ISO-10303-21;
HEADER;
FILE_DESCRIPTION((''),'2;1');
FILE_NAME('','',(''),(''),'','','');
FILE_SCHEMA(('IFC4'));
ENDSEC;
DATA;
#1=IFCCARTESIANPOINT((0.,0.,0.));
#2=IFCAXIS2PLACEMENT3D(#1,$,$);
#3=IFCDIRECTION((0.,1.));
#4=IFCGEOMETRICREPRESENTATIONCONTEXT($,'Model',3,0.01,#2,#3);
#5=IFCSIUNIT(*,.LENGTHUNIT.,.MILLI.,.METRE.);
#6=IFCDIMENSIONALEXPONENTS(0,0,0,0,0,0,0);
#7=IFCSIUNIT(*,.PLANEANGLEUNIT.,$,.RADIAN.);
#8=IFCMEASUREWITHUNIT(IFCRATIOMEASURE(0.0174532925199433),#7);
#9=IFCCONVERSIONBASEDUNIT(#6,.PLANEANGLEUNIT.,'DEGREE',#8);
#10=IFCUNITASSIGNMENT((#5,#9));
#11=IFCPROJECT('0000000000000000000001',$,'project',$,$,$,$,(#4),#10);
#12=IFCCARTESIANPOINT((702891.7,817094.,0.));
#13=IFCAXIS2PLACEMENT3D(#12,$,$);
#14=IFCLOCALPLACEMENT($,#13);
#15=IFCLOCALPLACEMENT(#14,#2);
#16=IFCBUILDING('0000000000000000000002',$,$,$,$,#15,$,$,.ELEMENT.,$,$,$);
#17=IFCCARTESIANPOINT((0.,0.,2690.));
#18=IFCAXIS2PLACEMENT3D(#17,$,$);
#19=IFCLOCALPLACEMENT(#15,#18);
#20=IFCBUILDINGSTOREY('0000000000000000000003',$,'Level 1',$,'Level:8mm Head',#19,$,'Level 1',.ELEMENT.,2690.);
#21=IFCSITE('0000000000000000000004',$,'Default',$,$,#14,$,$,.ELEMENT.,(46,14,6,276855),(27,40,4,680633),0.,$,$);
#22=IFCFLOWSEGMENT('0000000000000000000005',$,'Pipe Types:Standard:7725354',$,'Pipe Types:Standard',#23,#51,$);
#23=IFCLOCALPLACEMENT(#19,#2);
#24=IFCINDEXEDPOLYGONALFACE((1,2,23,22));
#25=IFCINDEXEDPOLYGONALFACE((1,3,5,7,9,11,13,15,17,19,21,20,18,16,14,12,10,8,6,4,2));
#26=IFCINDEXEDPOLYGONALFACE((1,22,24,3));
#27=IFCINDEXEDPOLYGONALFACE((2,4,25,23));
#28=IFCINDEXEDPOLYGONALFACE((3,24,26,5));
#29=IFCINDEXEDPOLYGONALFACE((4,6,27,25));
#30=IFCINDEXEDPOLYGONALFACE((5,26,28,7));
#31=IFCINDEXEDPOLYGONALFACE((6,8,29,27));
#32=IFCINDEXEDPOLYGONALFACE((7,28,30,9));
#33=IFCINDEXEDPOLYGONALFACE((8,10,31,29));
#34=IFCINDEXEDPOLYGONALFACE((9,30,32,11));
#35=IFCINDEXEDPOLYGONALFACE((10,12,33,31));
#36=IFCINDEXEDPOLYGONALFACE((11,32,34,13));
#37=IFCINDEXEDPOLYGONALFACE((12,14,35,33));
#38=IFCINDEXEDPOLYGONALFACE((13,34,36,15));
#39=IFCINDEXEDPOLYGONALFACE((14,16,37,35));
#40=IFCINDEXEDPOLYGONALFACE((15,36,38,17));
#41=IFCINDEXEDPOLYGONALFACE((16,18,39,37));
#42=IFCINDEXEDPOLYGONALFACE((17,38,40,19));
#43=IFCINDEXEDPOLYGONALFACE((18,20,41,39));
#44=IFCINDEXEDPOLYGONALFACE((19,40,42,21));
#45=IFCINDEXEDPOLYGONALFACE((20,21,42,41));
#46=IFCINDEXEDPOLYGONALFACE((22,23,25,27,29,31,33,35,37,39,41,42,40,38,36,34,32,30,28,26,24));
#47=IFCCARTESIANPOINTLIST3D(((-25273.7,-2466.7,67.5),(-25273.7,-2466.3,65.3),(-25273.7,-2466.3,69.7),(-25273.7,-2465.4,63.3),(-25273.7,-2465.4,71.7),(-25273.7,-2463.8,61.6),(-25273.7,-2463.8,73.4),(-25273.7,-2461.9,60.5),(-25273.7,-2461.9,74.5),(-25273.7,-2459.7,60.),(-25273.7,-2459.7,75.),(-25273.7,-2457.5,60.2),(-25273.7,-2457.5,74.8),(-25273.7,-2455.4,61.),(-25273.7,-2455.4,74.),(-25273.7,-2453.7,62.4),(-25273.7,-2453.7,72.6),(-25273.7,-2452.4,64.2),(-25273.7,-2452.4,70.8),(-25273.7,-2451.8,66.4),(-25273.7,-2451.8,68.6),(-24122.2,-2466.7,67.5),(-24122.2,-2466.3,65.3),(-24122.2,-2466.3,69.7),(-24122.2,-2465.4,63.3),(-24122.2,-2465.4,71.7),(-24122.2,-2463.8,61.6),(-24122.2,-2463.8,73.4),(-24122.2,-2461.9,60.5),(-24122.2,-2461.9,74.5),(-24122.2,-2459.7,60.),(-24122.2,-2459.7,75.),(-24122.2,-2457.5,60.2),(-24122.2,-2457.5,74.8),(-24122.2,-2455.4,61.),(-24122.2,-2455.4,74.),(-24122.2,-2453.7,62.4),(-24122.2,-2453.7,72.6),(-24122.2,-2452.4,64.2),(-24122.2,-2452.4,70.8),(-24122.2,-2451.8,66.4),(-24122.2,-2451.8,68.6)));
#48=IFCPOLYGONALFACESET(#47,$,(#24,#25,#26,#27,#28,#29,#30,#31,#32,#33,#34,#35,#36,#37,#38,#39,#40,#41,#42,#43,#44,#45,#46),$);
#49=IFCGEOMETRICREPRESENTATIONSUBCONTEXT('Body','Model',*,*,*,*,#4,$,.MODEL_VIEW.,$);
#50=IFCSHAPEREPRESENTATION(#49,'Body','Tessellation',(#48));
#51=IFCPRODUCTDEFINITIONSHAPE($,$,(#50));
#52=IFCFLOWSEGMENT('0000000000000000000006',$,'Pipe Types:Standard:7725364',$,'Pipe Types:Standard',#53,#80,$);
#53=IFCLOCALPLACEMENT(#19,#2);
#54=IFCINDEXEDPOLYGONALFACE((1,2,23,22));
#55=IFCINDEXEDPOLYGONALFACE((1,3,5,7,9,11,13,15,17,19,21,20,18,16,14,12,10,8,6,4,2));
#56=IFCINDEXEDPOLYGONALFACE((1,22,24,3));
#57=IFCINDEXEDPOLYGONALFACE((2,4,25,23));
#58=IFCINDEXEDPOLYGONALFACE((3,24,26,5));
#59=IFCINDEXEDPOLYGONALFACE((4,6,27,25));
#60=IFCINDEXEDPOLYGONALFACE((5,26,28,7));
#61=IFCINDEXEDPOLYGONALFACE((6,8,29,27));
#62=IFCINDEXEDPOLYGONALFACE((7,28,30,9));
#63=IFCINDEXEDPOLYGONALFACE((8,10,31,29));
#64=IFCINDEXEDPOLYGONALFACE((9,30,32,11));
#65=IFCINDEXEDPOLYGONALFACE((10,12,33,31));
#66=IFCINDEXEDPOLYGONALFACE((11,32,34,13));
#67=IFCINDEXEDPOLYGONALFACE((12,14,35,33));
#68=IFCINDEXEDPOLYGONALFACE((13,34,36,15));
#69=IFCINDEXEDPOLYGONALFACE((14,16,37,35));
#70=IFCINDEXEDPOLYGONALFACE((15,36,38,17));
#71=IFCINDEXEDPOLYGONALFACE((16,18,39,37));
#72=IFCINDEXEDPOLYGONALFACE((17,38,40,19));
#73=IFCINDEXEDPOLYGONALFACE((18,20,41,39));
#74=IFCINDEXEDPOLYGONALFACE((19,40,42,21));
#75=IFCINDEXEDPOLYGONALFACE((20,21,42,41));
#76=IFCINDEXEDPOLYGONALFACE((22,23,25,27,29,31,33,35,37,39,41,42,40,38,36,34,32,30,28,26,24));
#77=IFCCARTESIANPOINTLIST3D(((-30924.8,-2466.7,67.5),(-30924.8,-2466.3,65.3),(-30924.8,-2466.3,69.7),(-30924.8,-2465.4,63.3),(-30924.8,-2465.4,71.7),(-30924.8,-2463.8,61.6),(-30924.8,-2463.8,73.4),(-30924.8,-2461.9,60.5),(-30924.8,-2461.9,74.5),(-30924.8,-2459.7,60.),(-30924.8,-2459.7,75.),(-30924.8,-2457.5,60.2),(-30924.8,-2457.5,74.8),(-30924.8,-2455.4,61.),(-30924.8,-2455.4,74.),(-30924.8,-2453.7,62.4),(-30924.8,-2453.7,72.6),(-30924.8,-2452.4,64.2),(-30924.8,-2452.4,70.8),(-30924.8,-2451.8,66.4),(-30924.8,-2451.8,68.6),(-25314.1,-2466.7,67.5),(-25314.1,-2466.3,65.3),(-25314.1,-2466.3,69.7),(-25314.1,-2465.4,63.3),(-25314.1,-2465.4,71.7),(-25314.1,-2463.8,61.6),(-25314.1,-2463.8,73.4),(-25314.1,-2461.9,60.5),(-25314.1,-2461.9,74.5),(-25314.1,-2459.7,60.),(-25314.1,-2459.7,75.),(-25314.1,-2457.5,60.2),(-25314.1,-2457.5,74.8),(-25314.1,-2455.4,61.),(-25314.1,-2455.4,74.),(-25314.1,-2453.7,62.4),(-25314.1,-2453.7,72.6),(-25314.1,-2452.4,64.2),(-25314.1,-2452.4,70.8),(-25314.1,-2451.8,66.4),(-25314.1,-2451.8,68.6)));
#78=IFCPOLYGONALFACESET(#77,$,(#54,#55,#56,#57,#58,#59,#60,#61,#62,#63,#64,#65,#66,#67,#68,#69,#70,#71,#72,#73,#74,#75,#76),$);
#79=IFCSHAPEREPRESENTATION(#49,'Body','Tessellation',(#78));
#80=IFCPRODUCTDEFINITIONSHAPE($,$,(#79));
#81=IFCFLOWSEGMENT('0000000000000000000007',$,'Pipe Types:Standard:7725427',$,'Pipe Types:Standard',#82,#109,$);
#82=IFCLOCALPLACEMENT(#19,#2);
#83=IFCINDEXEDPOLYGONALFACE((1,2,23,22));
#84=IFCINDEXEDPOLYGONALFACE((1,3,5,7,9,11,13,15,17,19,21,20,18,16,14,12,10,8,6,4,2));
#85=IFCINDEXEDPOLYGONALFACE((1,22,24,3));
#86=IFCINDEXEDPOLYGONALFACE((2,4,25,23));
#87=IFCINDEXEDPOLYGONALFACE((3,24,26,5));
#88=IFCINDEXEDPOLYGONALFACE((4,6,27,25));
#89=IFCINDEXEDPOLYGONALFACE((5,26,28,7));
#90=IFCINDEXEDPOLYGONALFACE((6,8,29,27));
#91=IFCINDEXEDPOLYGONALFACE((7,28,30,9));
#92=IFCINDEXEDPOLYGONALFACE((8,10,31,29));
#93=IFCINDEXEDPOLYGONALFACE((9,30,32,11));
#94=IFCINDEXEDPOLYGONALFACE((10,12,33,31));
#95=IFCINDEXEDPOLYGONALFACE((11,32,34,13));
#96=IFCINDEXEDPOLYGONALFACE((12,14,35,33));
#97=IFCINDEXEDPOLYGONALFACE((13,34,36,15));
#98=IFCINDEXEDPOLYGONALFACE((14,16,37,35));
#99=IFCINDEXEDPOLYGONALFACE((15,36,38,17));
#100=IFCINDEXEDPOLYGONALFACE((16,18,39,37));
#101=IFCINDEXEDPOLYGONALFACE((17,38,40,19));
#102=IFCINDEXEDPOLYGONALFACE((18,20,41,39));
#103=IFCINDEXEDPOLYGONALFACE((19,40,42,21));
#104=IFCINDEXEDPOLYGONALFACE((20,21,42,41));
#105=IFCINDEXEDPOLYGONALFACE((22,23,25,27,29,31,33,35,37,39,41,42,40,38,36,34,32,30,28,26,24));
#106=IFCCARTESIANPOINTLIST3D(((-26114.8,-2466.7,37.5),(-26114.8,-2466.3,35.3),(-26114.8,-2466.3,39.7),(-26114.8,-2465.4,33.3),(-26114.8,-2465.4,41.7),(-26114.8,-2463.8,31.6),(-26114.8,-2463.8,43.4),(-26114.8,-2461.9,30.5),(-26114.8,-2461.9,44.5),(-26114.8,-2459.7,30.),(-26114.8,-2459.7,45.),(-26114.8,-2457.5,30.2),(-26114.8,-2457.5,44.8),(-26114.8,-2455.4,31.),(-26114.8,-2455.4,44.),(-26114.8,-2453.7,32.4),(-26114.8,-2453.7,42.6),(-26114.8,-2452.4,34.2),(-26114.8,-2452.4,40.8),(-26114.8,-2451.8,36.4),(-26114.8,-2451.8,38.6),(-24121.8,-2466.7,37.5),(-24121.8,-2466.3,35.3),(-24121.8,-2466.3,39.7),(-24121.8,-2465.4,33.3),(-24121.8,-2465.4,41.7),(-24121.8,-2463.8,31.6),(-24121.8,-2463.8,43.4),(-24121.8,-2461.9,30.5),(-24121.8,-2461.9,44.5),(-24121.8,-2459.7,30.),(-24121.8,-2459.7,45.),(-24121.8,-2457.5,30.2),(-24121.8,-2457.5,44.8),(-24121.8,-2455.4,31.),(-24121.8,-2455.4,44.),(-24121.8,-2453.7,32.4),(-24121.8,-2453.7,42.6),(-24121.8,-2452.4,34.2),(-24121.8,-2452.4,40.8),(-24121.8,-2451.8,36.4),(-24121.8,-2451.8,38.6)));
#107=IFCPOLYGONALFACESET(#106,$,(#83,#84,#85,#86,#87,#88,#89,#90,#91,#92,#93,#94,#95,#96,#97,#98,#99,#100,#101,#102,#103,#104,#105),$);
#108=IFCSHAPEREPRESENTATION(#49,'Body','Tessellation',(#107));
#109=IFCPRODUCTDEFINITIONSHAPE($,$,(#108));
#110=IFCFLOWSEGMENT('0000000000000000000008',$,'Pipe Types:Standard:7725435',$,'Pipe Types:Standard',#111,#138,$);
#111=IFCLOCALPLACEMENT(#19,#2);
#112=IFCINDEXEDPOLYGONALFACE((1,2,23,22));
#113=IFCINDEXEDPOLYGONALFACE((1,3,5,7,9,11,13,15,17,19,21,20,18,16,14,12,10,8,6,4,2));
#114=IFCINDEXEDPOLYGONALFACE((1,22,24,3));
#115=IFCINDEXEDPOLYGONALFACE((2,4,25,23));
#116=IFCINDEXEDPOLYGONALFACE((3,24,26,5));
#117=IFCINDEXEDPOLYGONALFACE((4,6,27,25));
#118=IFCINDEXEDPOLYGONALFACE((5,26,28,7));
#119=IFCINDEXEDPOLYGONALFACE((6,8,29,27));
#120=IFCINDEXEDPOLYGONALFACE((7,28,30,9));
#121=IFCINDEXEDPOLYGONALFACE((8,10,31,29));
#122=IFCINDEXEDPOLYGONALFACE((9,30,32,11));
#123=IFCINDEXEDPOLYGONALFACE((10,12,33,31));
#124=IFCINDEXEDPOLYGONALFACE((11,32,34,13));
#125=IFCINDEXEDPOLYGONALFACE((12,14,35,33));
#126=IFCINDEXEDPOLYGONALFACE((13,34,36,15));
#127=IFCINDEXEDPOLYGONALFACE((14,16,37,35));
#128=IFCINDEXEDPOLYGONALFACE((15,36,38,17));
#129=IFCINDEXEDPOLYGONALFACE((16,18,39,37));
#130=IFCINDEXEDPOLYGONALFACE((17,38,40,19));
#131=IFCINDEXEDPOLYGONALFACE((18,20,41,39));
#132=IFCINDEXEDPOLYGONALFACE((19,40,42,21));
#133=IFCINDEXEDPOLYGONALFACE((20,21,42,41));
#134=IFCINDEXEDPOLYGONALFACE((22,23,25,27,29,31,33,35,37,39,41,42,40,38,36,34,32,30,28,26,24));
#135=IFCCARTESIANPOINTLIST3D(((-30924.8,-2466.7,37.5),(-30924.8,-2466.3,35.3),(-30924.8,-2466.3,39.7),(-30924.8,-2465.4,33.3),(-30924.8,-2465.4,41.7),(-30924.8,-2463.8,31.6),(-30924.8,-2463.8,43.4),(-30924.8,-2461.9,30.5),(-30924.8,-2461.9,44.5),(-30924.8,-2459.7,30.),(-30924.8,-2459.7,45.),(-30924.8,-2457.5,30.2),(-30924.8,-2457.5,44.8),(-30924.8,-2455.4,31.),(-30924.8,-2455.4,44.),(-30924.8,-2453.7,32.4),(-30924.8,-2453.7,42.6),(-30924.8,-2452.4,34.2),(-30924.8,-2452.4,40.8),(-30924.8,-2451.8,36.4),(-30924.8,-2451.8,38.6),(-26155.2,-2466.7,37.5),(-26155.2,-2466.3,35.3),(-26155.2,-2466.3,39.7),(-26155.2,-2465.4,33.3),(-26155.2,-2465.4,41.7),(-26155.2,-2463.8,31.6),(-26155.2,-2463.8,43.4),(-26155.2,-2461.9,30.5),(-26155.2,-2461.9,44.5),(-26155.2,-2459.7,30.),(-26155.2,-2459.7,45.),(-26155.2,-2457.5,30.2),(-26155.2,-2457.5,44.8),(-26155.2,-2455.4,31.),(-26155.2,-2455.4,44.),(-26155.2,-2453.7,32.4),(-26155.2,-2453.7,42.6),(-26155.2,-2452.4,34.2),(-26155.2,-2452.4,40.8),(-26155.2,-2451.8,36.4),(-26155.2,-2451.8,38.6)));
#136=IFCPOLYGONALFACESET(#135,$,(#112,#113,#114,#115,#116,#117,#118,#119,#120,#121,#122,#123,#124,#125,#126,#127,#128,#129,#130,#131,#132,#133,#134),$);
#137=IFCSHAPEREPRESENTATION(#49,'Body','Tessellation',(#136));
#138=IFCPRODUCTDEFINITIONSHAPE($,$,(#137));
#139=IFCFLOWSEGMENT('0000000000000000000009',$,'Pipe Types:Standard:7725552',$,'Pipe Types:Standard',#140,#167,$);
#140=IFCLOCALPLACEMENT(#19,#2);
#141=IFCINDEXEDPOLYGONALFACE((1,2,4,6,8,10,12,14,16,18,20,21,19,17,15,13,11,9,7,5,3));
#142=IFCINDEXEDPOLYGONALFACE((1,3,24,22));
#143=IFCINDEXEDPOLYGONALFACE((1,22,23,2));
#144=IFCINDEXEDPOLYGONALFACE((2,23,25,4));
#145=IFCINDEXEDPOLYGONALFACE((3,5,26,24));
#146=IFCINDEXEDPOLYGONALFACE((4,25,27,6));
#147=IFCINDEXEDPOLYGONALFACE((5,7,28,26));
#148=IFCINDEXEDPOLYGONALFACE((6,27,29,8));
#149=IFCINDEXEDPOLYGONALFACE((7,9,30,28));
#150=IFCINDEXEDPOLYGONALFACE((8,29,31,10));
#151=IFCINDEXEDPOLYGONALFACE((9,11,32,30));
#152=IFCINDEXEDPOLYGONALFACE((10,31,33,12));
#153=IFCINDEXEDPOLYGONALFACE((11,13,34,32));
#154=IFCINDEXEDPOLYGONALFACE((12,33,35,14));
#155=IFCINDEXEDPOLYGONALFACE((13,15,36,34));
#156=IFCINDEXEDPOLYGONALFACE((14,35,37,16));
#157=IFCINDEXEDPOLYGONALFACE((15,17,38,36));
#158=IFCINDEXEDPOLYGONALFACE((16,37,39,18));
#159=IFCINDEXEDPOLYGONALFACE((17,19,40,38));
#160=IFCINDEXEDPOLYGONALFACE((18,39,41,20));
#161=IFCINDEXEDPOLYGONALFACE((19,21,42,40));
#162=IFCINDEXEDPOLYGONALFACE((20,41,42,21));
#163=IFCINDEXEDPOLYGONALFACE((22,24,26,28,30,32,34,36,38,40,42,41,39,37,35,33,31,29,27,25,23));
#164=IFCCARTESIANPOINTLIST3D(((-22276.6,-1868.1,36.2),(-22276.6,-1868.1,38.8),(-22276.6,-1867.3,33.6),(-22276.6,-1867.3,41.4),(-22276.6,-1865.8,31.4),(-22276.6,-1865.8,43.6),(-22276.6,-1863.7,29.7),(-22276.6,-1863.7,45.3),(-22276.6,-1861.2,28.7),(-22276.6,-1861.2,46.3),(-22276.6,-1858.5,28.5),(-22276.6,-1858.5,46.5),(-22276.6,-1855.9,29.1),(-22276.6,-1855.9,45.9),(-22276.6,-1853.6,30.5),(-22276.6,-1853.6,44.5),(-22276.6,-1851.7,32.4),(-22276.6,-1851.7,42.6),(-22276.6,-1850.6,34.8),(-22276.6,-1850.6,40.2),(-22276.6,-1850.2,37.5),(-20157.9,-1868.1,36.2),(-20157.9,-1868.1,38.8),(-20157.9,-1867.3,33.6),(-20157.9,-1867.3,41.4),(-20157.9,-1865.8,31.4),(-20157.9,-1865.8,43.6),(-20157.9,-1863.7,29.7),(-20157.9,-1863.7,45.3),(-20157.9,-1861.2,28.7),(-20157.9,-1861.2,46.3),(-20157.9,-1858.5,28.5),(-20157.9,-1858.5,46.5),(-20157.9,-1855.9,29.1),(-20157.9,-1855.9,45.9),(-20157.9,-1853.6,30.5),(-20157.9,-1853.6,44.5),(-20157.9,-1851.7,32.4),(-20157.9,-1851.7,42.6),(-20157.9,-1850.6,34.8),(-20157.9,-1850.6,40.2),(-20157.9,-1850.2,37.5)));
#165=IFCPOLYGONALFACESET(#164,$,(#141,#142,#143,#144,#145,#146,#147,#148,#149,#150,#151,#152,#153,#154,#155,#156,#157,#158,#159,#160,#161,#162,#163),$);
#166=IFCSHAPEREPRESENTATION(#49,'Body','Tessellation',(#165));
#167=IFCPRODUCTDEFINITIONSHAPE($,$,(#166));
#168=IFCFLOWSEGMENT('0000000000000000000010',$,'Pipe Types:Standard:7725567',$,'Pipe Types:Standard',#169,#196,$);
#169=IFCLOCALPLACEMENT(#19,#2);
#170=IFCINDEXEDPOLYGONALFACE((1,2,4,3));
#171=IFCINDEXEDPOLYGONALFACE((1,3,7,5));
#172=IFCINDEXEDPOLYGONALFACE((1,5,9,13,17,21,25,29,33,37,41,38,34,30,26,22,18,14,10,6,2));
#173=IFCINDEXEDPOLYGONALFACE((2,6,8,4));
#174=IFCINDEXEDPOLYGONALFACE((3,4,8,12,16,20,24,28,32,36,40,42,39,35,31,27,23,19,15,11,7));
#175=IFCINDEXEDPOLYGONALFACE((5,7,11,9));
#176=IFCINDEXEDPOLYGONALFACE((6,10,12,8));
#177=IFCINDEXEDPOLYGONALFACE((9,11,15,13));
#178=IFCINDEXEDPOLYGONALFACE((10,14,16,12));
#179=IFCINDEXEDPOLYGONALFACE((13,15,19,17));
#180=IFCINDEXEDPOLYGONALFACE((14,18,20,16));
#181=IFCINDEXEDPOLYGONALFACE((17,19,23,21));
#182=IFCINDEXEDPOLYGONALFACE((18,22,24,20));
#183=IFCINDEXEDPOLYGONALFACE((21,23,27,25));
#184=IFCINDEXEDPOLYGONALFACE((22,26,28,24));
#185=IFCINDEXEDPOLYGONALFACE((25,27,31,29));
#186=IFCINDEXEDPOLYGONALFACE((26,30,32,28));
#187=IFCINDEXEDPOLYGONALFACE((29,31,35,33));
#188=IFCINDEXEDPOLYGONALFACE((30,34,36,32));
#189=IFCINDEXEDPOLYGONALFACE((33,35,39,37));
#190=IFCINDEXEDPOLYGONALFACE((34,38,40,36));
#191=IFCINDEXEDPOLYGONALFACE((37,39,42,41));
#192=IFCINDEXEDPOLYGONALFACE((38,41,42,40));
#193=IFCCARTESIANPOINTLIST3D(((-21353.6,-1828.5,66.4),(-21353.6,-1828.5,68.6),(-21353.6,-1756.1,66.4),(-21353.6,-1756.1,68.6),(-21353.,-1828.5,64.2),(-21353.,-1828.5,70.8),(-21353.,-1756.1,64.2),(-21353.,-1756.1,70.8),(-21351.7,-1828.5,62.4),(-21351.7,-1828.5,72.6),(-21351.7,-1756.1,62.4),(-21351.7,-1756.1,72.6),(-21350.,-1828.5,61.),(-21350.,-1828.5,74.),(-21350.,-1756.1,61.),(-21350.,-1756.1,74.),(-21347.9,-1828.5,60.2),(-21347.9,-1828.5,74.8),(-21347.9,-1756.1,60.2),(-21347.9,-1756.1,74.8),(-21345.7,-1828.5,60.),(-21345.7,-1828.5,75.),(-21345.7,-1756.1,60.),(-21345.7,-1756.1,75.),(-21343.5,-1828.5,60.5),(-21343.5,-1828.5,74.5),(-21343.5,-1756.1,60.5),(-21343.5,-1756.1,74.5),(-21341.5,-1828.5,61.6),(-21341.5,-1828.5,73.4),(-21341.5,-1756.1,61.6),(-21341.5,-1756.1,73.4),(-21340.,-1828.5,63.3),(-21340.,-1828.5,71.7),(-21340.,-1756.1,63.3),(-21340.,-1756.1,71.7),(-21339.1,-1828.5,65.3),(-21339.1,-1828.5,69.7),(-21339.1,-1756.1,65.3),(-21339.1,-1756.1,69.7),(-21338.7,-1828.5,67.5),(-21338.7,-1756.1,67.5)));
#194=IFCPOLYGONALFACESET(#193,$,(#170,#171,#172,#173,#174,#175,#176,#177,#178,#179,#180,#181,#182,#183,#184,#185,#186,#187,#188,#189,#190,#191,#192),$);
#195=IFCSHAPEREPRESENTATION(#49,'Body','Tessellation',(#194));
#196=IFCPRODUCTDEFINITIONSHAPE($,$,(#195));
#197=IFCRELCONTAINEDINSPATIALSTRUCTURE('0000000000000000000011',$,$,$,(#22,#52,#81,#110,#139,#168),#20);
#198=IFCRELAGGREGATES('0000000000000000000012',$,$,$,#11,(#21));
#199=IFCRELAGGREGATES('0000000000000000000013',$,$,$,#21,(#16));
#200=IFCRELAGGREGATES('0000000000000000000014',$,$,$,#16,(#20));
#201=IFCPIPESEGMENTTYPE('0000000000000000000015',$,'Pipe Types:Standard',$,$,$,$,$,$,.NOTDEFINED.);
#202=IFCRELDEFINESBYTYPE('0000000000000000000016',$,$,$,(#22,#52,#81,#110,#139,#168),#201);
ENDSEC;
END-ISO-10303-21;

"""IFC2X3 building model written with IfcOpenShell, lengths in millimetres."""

from ifc_helpers import new_model, entity, si_unit, converted_unit, direction, frame, frame_2d, origin, origin_2d_with_axis, place, context, subcontext, project, spatial, circle, extrude, type_object, element, save


model = new_model("IFC2X3")

# Units and contexts
model_context = context("Model", 3, precision=0.01, world=origin(), true_north=direction((0.0, 1.0)))
body_context = subcontext(model_context, "Body", "Model", "MODEL_VIEW")
ifc_project = project(units=[si_unit("LENGTHUNIT", "METRE", prefix="MILLI"), converted_unit("PLANEANGLEUNIT", "DEGREE", entity("IfcRatioMeasure", 0.0174532925199433), si_unit("PLANEANGLEUNIT", "RADIAN"), dimensions=[0, 0, 0, 0, 0, 0, 0])], contexts=[model_context])

# Site, building, storey
site_placement = place(None, frame((702891.7, 817094.0, 0.0)))
site = spatial("IfcSite", under=ifc_project, at=site_placement, Name="Default", CompositionType="ELEMENT", RefLatitude=(46, 14, 6, 276855), RefLongitude=(27, 40, 4, 680633), RefElevation=0.0)
building_placement = place(site_placement, origin())
building = spatial("IfcBuilding", under=site, at=building_placement, CompositionType="ELEMENT")
storey_placement = place(building_placement, frame((0.0, 0.0, 2690.0)))
storey = spatial("IfcBuildingStorey", under=building, at=storey_placement, Name="Level 1", ObjectType="Level:8mm Head", LongName="Level 1", CompositionType="ELEMENT", Elevation=2690.0)

# Flow segments
pipe_segment_type = type_object("IfcPipeSegmentType", Name="Pipe Types:Standard", PredefinedType="NOTDEFINED")
flow_segment_1_placement = place(storey_placement, origin())
element("IfcFlowSegment", 1, at=flow_segment_1_placement, inside=storey, type_object=pipe_segment_type, Name="Pipe Types:Standard:7725354", ObjectType="Pipe Types:Standard", context=body_context, shape_type="SweptSolid", body=[
    extrude(circle(Radius=7.5, at=origin_2d_with_axis()), frame((-25273.7, -2459.2, 67.5), z_axis=(1.0, 0.0, 0.0), x_axis=(0.0, -1.0, 0.0)), (0.0, 0.0, 1.0), 1151.5),
])
flow_segment_2_placement = place(storey_placement, origin())
element("IfcFlowSegment", 2, at=flow_segment_2_placement, inside=storey, type_object=pipe_segment_type, Name="Pipe Types:Standard:7725364", ObjectType="Pipe Types:Standard", context=body_context, shape_type="SweptSolid", body=[
    extrude(circle(Radius=7.5, at=origin_2d_with_axis()), frame((-30924.8, -2459.2, 67.5), z_axis=(1.0, 0.0, 0.0), x_axis=(0.0, -1.0, 0.0)), (0.0, 0.0, 1.0), 5610.8),
])
flow_segment_3_placement = place(storey_placement, origin())
element("IfcFlowSegment", 3, at=flow_segment_3_placement, inside=storey, type_object=pipe_segment_type, Name="Pipe Types:Standard:7725427", ObjectType="Pipe Types:Standard", context=body_context, shape_type="SweptSolid", body=[
    extrude(circle(Radius=7.5, at=frame_2d((0.0, 0.0), x_axis=(1.0, 0.0))), frame((-26114.8, -2459.2, 37.5), z_axis=(1.0, 0.0, 0.0), x_axis=(0.0, -1.0, 0.0)), (0.0, 0.0, 1.0), 1993.0),
])
flow_segment_4_placement = place(storey_placement, origin())
element("IfcFlowSegment", 4, at=flow_segment_4_placement, inside=storey, type_object=pipe_segment_type, Name="Pipe Types:Standard:7725435", ObjectType="Pipe Types:Standard", context=body_context, shape_type="SweptSolid", body=[
    extrude(circle(Radius=7.5, at=origin_2d_with_axis()), frame((-30924.8, -2459.2, 37.5), z_axis=(1.0, 0.0, 0.0), x_axis=(0.0, -1.0, 0.0)), (0.0, 0.0, 1.0), 4769.6),
])
flow_segment_5_placement = place(storey_placement, origin())
element("IfcFlowSegment", 5, at=flow_segment_5_placement, inside=storey, type_object=pipe_segment_type, Name="Pipe Types:Standard:7725552", ObjectType="Pipe Types:Standard", context=body_context, shape_type="SweptSolid", body=[
    extrude(circle(Radius=9.0, at=frame_2d((0.0, 0.0), x_axis=(1.0, 0.0))), frame((-22276.6, -1859.2, 37.5), z_axis=(1.0, 0.0, 0.0), x_axis=(0.0, 1.0, 0.0)), (0.0, 0.0, 1.0), 2118.7),
])
flow_segment_6_placement = place(storey_placement, origin())
element("IfcFlowSegment", 6, at=flow_segment_6_placement, inside=storey, type_object=pipe_segment_type, Name="Pipe Types:Standard:7725567", ObjectType="Pipe Types:Standard", context=body_context, shape_type="SweptSolid", body=[
    extrude(circle(Radius=7.5, at=origin_2d_with_axis()), frame((-21346.2, -1828.5, 67.5), z_axis=(0.0, 1.0, 0.0), x_axis=(1.0, 0.0, 0.0)), (0.0, 0.0, 1.0), 72.4),
])

save(model, "model.ifc")
